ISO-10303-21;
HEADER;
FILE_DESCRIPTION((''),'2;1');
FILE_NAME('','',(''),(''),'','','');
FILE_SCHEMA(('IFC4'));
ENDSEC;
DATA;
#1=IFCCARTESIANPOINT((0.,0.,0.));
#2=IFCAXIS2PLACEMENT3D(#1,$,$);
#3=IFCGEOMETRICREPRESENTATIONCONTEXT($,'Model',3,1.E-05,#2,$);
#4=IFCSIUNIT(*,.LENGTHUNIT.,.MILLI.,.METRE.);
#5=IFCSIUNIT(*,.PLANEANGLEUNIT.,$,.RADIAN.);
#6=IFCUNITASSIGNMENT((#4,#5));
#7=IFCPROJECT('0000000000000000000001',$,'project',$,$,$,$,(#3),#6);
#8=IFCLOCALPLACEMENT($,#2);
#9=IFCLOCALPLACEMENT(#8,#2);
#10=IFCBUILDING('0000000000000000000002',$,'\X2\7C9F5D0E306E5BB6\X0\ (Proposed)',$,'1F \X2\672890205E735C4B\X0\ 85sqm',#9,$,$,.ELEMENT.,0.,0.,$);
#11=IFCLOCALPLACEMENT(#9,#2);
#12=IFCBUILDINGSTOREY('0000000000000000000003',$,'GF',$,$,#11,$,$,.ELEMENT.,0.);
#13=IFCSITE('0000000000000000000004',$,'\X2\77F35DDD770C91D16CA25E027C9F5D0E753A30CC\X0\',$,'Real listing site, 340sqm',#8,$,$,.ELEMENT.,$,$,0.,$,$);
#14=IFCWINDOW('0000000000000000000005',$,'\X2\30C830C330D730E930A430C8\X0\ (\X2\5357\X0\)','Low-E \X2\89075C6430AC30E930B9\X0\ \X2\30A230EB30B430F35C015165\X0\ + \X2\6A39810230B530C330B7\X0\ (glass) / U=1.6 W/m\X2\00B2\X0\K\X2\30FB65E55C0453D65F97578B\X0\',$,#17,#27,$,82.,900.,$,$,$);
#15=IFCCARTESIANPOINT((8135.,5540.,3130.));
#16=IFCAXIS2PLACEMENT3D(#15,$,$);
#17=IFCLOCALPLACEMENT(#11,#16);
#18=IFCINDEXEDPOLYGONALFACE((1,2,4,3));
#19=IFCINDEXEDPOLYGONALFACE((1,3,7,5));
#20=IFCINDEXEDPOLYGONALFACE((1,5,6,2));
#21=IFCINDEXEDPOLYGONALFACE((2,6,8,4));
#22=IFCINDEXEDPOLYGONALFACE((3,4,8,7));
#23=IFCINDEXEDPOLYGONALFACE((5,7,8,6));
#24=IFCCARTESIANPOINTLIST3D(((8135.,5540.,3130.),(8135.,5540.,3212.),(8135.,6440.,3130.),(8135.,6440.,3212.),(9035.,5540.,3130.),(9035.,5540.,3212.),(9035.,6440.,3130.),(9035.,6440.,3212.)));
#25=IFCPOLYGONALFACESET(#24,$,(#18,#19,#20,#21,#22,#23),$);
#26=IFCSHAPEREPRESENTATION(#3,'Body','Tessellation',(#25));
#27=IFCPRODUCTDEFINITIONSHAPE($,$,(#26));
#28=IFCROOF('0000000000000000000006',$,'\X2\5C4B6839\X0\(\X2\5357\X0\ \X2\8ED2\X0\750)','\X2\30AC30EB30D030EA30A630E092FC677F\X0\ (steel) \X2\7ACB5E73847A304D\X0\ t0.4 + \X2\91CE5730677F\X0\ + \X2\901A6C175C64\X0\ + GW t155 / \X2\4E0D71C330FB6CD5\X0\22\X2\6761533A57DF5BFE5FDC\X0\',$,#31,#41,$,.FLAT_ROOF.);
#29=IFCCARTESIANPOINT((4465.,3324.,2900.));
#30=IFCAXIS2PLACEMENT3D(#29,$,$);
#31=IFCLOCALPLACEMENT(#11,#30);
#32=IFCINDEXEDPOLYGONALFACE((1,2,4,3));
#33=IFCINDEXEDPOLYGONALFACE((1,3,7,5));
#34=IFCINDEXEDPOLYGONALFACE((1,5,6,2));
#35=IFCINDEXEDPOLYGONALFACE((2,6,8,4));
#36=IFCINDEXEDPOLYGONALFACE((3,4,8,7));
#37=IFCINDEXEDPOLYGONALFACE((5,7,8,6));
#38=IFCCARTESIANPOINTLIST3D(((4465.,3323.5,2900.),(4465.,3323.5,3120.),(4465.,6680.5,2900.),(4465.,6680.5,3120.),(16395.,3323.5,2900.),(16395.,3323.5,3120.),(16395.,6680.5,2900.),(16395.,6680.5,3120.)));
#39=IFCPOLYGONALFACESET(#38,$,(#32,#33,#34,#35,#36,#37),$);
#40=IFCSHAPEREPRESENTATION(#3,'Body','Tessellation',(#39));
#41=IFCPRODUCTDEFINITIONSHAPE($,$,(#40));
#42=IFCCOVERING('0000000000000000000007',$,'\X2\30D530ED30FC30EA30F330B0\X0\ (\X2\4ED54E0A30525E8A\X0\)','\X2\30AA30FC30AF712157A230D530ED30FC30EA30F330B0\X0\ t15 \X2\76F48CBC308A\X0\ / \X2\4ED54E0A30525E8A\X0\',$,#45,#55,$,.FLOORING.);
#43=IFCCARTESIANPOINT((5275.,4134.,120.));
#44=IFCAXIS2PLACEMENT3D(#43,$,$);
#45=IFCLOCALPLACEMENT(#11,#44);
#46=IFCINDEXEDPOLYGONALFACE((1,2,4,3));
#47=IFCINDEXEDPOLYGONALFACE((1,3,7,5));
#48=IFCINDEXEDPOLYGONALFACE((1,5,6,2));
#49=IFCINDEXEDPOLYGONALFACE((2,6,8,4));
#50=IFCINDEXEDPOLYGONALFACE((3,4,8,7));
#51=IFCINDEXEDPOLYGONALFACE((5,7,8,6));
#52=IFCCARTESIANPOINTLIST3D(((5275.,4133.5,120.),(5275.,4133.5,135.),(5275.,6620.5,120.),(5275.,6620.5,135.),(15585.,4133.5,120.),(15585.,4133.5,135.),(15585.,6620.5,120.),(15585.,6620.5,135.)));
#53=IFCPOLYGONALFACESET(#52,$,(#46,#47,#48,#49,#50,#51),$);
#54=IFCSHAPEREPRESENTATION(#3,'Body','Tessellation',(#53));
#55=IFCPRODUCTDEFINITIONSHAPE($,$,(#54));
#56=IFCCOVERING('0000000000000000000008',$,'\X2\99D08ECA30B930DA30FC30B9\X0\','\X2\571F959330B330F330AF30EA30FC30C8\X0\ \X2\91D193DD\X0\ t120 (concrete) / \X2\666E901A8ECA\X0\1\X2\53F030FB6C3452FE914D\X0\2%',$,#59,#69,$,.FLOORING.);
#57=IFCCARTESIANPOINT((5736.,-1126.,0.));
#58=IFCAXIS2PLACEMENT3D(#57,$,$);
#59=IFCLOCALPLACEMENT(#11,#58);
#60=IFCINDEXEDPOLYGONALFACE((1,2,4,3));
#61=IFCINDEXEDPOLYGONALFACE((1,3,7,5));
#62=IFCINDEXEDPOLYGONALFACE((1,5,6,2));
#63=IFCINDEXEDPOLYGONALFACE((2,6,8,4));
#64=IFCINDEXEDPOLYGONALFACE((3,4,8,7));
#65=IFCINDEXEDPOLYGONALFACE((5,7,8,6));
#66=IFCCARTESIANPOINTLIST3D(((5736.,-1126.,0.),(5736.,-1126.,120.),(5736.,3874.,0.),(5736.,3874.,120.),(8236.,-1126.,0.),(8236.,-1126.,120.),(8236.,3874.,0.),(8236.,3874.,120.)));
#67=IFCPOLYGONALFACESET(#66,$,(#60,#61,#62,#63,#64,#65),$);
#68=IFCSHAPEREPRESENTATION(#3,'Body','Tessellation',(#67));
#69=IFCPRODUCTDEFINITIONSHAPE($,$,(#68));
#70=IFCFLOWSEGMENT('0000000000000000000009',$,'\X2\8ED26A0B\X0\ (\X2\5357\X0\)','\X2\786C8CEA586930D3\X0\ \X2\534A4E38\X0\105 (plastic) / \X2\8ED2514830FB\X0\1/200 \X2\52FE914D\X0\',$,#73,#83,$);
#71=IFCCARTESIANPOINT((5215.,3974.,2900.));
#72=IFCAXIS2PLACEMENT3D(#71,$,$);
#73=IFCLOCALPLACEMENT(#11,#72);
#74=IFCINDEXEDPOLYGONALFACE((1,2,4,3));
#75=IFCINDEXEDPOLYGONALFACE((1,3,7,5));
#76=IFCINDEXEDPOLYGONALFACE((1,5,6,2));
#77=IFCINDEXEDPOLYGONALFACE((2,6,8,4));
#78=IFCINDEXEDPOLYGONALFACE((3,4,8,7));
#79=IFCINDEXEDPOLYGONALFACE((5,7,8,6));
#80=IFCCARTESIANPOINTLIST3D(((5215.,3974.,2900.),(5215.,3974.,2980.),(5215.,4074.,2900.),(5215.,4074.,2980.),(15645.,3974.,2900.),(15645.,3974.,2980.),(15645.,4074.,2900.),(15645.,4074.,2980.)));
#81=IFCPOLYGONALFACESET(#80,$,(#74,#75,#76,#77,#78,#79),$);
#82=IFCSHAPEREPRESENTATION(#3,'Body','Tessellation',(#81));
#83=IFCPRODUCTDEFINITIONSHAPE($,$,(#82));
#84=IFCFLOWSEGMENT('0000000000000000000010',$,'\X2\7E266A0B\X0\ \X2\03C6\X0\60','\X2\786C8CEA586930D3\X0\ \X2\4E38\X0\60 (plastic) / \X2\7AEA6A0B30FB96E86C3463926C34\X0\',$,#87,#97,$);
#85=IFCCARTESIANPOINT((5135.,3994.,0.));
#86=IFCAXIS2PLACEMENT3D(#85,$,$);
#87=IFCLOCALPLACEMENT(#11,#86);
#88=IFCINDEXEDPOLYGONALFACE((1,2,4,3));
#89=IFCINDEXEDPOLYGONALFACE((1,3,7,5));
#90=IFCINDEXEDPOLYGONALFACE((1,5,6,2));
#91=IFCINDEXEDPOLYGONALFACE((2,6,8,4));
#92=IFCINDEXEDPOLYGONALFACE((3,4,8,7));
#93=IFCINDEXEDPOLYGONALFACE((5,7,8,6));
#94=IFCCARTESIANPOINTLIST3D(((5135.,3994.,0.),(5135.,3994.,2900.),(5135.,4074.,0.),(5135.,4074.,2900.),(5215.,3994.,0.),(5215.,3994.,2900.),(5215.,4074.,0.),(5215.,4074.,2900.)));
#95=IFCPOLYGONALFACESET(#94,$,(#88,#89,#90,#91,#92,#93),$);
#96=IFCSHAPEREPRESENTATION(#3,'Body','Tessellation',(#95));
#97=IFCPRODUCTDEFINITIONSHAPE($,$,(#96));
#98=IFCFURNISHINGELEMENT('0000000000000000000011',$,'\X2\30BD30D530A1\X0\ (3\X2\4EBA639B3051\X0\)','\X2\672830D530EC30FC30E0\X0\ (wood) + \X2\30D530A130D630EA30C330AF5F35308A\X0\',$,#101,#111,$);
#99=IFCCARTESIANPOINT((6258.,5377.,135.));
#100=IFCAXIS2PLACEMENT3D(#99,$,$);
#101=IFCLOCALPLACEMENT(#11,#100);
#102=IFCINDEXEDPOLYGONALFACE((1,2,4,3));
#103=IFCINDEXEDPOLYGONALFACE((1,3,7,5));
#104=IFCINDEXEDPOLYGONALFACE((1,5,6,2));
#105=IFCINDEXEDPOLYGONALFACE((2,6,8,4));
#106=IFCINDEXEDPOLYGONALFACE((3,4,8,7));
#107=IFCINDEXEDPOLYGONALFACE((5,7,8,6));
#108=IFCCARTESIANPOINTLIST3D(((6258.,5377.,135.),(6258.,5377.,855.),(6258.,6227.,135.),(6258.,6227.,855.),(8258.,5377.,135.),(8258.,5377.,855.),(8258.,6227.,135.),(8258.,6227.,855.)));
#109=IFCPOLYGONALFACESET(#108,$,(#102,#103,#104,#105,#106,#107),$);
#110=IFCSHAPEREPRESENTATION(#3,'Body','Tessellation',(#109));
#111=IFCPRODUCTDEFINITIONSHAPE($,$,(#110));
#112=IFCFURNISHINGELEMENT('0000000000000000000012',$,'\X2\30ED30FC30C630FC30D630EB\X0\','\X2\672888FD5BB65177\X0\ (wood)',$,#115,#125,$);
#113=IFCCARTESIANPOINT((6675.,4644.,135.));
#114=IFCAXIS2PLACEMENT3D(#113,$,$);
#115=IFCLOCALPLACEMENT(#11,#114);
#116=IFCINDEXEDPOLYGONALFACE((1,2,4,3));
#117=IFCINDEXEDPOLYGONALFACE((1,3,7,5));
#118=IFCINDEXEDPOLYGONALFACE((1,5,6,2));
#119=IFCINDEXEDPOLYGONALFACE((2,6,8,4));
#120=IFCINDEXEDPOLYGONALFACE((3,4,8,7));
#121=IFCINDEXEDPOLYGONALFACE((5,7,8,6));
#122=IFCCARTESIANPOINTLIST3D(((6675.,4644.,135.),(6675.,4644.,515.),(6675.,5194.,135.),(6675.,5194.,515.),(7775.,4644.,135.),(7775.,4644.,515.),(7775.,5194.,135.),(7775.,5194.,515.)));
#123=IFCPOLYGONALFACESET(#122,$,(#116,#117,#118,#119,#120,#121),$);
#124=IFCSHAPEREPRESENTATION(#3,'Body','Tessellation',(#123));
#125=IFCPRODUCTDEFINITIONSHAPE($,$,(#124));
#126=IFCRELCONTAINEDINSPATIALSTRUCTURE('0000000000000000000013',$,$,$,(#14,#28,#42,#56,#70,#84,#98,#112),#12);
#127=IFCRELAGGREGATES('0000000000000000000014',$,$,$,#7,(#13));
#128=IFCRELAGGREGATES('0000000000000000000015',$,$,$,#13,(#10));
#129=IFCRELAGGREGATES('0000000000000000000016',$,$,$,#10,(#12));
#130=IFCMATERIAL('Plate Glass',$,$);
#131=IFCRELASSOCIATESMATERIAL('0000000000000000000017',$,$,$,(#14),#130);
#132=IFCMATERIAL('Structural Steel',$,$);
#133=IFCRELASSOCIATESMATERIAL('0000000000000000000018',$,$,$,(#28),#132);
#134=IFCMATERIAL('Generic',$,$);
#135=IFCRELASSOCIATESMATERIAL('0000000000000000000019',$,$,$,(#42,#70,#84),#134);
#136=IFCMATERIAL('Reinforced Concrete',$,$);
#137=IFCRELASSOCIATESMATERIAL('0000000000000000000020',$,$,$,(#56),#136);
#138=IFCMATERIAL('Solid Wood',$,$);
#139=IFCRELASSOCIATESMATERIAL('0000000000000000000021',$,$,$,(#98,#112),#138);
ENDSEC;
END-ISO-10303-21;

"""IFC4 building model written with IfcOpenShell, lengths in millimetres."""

from ifc_helpers import new_model, si_unit, frame, frame_2d, origin, place, context, project, spatial, rectangle, extrude, material, element, save


model = new_model("IFC4")

# Units and contexts
model_context = context("Model", 3, precision=1e-05, world=origin())
ifc_project = project(units=[si_unit("LENGTHUNIT", "METRE", prefix="MILLI"), si_unit("PLANEANGLEUNIT", "RADIAN")], contexts=[model_context])

# Site, building, storey
site_placement = place(None, origin())
site = spatial("IfcSite", under=ifc_project, at=site_placement, Name="石川県金沢市粟崎町ヌ", ObjectType="Real listing site, 340sqm", CompositionType="ELEMENT", RefElevation=0.0)
building_placement = place(site_placement, origin())
building = spatial("IfcBuilding", under=site, at=building_placement, Name="粟崎の家 (Proposed)", ObjectType="1F 木造平屋 85sqm", CompositionType="ELEMENT", ElevationOfRefHeight=0.0, ElevationOfTerrain=0.0)
storey_placement = place(building_placement, origin())
storey = spatial("IfcBuildingStorey", under=building, at=storey_placement, Name="GF", CompositionType="ELEMENT", Elevation=0.0)

# Shared definitions
ifc_material_1 = material(Name="Solid Wood")

# Shared definitions
ifc_material_2 = material(Name="Reinforced Concrete")

# Shared definitions
ifc_material_3 = material(Name="Plate Glass")

# Window
window_1_placement = place(storey_placement, frame((8135.0, 5540.0, 3130.0)))
element("IfcWindow", 1, at=window_1_placement, inside=storey, material=ifc_material_3, Name="トップライト (南)", Description="Low-E 複層ガラス アルゴン封入 + 樹脂サッシ (glass) / U=1.6 W/m²K・日射取得型", OverallHeight=82.0, OverallWidth=900.0, context=model_context, shape_type="SweptSolid", body=[
    extrude(rectangle(XDim=900.0, YDim=900.0, at=frame_2d((450.0, 450.0))), frame((8135.0, 5540.0, 3130.0)), (0.0, 0.0, 1.0), 82.0),
])

# Roof
ifc_material_4 = material(Name="Structural Steel")
roof_1_placement = place(storey_placement, frame((4465.0, 3324.0, 2900.0)))
element("IfcRoof", 2, at=roof_1_placement, inside=storey, material=ifc_material_4, Name="屋根(南 軒750)", Description="ガルバリウム鋼板 (steel) 立平葺き t0.4 + 野地板 + 通気層 + GW t155 / 不燃・法22条区域対応", PredefinedType="FLAT_ROOF", context=model_context, shape_type="SweptSolid", body=[
    extrude(rectangle(XDim=11930.0, YDim=3357.0, at=frame_2d((5965.0, 1678.0))), frame((4465.0, 3324.0, 2900.0)), (0.0, 0.0, 1.0), 220.0),
])

# Coverings
ifc_material_5 = material(Name="Generic")
covering_1_placement = place(storey_placement, frame((5275.0, 4134.0, 120.0)))
element("IfcCovering", 3, at=covering_1_placement, inside=storey, material=ifc_material_5, Name="フローリング (仕上げ床)", Description="オーク無垢フローリング t15 直貼り / 仕上げ床", PredefinedType="FLOORING", context=model_context, shape_type="SweptSolid", body=[
    extrude(rectangle(XDim=10310.0, YDim=2487.0, at=frame_2d((5155.0, 1243.0))), frame((5275.0, 4134.0, 120.0)), (0.0, 0.0, 1.0), 15.0),
])
covering_2_placement = place(storey_placement, frame((5736.0, -1126.0, 0.0)))
element("IfcCovering", 4, at=covering_2_placement, inside=storey, material=ifc_material_2, Name="駐車スペース", Description="土間コンクリート 金鏝 t120 (concrete) / 普通車1台・水勾配2%", PredefinedType="FLOORING", context=model_context, shape_type="SweptSolid", body=[
    extrude(rectangle(XDim=2500.0, YDim=5000.0, at=frame_2d((1250.0, 2500.0))), frame((5736.0, -1126.0, 0.0)), (0.0, 0.0, 1.0), 120.0),
])

# Flow segments
flow_segment_1_placement = place(storey_placement, frame((5215.0, 3974.0, 2900.0)))
element("IfcFlowSegment", 5, at=flow_segment_1_placement, inside=storey, material=ifc_material_5, Name="軒樋 (南)", Description="硬質塩ビ 半丸105 (plastic) / 軒先・1/200 勾配", context=model_context, shape_type="SweptSolid", body=[
    extrude(rectangle(XDim=10430.0, YDim=100.0, at=frame_2d((5215.0, 50.0))), frame((5215.0, 3974.0, 2900.0)), (0.0, 0.0, 1.0), 80.0),
])
flow_segment_2_placement = place(storey_placement, frame((5135.0, 3994.0, 0.0)))
element("IfcFlowSegment", 6, at=flow_segment_2_placement, inside=storey, material=ifc_material_5, Name="縦樋 φ60", Description="硬質塩ビ 丸60 (plastic) / 竪樋・雨水排水", context=model_context, shape_type="SweptSolid", body=[
    extrude(rectangle(XDim=80.0, YDim=80.0, at=frame_2d((40.0, 40.0))), frame((5135.0, 3994.0, 0.0)), (0.0, 0.0, 1.0), 2900.0),
])

# Furnishing elements
furnishing_1_placement = place(storey_placement, frame((6258.0, 5377.0, 135.0)))
element("IfcFurnishingElement", 7, at=furnishing_1_placement, inside=storey, material=ifc_material_1, Name="ソファ (3人掛け)", Description="木フレーム (wood) + ファブリック張り", context=model_context, shape_type="SweptSolid", body=[
    extrude(rectangle(XDim=2000.0, YDim=850.0, at=frame_2d((1000.0, 425.0))), frame((6258.0, 5377.0, 135.0)), (0.0, 0.0, 1.0), 720.0),
])
furnishing_2_placement = place(storey_placement, frame((6675.0, 4644.0, 135.0)))
element("IfcFurnishingElement", 8, at=furnishing_2_placement, inside=storey, material=ifc_material_1, Name="ローテーブル", Description="木製家具 (wood)", context=model_context, shape_type="SweptSolid", body=[
    extrude(rectangle(XDim=1100.0, YDim=550.0, at=frame_2d((550.0, 275.0))), frame((6675.0, 4644.0, 135.0)), (0.0, 0.0, 1.0), 380.0),
])

save(model, "model.ifc")
